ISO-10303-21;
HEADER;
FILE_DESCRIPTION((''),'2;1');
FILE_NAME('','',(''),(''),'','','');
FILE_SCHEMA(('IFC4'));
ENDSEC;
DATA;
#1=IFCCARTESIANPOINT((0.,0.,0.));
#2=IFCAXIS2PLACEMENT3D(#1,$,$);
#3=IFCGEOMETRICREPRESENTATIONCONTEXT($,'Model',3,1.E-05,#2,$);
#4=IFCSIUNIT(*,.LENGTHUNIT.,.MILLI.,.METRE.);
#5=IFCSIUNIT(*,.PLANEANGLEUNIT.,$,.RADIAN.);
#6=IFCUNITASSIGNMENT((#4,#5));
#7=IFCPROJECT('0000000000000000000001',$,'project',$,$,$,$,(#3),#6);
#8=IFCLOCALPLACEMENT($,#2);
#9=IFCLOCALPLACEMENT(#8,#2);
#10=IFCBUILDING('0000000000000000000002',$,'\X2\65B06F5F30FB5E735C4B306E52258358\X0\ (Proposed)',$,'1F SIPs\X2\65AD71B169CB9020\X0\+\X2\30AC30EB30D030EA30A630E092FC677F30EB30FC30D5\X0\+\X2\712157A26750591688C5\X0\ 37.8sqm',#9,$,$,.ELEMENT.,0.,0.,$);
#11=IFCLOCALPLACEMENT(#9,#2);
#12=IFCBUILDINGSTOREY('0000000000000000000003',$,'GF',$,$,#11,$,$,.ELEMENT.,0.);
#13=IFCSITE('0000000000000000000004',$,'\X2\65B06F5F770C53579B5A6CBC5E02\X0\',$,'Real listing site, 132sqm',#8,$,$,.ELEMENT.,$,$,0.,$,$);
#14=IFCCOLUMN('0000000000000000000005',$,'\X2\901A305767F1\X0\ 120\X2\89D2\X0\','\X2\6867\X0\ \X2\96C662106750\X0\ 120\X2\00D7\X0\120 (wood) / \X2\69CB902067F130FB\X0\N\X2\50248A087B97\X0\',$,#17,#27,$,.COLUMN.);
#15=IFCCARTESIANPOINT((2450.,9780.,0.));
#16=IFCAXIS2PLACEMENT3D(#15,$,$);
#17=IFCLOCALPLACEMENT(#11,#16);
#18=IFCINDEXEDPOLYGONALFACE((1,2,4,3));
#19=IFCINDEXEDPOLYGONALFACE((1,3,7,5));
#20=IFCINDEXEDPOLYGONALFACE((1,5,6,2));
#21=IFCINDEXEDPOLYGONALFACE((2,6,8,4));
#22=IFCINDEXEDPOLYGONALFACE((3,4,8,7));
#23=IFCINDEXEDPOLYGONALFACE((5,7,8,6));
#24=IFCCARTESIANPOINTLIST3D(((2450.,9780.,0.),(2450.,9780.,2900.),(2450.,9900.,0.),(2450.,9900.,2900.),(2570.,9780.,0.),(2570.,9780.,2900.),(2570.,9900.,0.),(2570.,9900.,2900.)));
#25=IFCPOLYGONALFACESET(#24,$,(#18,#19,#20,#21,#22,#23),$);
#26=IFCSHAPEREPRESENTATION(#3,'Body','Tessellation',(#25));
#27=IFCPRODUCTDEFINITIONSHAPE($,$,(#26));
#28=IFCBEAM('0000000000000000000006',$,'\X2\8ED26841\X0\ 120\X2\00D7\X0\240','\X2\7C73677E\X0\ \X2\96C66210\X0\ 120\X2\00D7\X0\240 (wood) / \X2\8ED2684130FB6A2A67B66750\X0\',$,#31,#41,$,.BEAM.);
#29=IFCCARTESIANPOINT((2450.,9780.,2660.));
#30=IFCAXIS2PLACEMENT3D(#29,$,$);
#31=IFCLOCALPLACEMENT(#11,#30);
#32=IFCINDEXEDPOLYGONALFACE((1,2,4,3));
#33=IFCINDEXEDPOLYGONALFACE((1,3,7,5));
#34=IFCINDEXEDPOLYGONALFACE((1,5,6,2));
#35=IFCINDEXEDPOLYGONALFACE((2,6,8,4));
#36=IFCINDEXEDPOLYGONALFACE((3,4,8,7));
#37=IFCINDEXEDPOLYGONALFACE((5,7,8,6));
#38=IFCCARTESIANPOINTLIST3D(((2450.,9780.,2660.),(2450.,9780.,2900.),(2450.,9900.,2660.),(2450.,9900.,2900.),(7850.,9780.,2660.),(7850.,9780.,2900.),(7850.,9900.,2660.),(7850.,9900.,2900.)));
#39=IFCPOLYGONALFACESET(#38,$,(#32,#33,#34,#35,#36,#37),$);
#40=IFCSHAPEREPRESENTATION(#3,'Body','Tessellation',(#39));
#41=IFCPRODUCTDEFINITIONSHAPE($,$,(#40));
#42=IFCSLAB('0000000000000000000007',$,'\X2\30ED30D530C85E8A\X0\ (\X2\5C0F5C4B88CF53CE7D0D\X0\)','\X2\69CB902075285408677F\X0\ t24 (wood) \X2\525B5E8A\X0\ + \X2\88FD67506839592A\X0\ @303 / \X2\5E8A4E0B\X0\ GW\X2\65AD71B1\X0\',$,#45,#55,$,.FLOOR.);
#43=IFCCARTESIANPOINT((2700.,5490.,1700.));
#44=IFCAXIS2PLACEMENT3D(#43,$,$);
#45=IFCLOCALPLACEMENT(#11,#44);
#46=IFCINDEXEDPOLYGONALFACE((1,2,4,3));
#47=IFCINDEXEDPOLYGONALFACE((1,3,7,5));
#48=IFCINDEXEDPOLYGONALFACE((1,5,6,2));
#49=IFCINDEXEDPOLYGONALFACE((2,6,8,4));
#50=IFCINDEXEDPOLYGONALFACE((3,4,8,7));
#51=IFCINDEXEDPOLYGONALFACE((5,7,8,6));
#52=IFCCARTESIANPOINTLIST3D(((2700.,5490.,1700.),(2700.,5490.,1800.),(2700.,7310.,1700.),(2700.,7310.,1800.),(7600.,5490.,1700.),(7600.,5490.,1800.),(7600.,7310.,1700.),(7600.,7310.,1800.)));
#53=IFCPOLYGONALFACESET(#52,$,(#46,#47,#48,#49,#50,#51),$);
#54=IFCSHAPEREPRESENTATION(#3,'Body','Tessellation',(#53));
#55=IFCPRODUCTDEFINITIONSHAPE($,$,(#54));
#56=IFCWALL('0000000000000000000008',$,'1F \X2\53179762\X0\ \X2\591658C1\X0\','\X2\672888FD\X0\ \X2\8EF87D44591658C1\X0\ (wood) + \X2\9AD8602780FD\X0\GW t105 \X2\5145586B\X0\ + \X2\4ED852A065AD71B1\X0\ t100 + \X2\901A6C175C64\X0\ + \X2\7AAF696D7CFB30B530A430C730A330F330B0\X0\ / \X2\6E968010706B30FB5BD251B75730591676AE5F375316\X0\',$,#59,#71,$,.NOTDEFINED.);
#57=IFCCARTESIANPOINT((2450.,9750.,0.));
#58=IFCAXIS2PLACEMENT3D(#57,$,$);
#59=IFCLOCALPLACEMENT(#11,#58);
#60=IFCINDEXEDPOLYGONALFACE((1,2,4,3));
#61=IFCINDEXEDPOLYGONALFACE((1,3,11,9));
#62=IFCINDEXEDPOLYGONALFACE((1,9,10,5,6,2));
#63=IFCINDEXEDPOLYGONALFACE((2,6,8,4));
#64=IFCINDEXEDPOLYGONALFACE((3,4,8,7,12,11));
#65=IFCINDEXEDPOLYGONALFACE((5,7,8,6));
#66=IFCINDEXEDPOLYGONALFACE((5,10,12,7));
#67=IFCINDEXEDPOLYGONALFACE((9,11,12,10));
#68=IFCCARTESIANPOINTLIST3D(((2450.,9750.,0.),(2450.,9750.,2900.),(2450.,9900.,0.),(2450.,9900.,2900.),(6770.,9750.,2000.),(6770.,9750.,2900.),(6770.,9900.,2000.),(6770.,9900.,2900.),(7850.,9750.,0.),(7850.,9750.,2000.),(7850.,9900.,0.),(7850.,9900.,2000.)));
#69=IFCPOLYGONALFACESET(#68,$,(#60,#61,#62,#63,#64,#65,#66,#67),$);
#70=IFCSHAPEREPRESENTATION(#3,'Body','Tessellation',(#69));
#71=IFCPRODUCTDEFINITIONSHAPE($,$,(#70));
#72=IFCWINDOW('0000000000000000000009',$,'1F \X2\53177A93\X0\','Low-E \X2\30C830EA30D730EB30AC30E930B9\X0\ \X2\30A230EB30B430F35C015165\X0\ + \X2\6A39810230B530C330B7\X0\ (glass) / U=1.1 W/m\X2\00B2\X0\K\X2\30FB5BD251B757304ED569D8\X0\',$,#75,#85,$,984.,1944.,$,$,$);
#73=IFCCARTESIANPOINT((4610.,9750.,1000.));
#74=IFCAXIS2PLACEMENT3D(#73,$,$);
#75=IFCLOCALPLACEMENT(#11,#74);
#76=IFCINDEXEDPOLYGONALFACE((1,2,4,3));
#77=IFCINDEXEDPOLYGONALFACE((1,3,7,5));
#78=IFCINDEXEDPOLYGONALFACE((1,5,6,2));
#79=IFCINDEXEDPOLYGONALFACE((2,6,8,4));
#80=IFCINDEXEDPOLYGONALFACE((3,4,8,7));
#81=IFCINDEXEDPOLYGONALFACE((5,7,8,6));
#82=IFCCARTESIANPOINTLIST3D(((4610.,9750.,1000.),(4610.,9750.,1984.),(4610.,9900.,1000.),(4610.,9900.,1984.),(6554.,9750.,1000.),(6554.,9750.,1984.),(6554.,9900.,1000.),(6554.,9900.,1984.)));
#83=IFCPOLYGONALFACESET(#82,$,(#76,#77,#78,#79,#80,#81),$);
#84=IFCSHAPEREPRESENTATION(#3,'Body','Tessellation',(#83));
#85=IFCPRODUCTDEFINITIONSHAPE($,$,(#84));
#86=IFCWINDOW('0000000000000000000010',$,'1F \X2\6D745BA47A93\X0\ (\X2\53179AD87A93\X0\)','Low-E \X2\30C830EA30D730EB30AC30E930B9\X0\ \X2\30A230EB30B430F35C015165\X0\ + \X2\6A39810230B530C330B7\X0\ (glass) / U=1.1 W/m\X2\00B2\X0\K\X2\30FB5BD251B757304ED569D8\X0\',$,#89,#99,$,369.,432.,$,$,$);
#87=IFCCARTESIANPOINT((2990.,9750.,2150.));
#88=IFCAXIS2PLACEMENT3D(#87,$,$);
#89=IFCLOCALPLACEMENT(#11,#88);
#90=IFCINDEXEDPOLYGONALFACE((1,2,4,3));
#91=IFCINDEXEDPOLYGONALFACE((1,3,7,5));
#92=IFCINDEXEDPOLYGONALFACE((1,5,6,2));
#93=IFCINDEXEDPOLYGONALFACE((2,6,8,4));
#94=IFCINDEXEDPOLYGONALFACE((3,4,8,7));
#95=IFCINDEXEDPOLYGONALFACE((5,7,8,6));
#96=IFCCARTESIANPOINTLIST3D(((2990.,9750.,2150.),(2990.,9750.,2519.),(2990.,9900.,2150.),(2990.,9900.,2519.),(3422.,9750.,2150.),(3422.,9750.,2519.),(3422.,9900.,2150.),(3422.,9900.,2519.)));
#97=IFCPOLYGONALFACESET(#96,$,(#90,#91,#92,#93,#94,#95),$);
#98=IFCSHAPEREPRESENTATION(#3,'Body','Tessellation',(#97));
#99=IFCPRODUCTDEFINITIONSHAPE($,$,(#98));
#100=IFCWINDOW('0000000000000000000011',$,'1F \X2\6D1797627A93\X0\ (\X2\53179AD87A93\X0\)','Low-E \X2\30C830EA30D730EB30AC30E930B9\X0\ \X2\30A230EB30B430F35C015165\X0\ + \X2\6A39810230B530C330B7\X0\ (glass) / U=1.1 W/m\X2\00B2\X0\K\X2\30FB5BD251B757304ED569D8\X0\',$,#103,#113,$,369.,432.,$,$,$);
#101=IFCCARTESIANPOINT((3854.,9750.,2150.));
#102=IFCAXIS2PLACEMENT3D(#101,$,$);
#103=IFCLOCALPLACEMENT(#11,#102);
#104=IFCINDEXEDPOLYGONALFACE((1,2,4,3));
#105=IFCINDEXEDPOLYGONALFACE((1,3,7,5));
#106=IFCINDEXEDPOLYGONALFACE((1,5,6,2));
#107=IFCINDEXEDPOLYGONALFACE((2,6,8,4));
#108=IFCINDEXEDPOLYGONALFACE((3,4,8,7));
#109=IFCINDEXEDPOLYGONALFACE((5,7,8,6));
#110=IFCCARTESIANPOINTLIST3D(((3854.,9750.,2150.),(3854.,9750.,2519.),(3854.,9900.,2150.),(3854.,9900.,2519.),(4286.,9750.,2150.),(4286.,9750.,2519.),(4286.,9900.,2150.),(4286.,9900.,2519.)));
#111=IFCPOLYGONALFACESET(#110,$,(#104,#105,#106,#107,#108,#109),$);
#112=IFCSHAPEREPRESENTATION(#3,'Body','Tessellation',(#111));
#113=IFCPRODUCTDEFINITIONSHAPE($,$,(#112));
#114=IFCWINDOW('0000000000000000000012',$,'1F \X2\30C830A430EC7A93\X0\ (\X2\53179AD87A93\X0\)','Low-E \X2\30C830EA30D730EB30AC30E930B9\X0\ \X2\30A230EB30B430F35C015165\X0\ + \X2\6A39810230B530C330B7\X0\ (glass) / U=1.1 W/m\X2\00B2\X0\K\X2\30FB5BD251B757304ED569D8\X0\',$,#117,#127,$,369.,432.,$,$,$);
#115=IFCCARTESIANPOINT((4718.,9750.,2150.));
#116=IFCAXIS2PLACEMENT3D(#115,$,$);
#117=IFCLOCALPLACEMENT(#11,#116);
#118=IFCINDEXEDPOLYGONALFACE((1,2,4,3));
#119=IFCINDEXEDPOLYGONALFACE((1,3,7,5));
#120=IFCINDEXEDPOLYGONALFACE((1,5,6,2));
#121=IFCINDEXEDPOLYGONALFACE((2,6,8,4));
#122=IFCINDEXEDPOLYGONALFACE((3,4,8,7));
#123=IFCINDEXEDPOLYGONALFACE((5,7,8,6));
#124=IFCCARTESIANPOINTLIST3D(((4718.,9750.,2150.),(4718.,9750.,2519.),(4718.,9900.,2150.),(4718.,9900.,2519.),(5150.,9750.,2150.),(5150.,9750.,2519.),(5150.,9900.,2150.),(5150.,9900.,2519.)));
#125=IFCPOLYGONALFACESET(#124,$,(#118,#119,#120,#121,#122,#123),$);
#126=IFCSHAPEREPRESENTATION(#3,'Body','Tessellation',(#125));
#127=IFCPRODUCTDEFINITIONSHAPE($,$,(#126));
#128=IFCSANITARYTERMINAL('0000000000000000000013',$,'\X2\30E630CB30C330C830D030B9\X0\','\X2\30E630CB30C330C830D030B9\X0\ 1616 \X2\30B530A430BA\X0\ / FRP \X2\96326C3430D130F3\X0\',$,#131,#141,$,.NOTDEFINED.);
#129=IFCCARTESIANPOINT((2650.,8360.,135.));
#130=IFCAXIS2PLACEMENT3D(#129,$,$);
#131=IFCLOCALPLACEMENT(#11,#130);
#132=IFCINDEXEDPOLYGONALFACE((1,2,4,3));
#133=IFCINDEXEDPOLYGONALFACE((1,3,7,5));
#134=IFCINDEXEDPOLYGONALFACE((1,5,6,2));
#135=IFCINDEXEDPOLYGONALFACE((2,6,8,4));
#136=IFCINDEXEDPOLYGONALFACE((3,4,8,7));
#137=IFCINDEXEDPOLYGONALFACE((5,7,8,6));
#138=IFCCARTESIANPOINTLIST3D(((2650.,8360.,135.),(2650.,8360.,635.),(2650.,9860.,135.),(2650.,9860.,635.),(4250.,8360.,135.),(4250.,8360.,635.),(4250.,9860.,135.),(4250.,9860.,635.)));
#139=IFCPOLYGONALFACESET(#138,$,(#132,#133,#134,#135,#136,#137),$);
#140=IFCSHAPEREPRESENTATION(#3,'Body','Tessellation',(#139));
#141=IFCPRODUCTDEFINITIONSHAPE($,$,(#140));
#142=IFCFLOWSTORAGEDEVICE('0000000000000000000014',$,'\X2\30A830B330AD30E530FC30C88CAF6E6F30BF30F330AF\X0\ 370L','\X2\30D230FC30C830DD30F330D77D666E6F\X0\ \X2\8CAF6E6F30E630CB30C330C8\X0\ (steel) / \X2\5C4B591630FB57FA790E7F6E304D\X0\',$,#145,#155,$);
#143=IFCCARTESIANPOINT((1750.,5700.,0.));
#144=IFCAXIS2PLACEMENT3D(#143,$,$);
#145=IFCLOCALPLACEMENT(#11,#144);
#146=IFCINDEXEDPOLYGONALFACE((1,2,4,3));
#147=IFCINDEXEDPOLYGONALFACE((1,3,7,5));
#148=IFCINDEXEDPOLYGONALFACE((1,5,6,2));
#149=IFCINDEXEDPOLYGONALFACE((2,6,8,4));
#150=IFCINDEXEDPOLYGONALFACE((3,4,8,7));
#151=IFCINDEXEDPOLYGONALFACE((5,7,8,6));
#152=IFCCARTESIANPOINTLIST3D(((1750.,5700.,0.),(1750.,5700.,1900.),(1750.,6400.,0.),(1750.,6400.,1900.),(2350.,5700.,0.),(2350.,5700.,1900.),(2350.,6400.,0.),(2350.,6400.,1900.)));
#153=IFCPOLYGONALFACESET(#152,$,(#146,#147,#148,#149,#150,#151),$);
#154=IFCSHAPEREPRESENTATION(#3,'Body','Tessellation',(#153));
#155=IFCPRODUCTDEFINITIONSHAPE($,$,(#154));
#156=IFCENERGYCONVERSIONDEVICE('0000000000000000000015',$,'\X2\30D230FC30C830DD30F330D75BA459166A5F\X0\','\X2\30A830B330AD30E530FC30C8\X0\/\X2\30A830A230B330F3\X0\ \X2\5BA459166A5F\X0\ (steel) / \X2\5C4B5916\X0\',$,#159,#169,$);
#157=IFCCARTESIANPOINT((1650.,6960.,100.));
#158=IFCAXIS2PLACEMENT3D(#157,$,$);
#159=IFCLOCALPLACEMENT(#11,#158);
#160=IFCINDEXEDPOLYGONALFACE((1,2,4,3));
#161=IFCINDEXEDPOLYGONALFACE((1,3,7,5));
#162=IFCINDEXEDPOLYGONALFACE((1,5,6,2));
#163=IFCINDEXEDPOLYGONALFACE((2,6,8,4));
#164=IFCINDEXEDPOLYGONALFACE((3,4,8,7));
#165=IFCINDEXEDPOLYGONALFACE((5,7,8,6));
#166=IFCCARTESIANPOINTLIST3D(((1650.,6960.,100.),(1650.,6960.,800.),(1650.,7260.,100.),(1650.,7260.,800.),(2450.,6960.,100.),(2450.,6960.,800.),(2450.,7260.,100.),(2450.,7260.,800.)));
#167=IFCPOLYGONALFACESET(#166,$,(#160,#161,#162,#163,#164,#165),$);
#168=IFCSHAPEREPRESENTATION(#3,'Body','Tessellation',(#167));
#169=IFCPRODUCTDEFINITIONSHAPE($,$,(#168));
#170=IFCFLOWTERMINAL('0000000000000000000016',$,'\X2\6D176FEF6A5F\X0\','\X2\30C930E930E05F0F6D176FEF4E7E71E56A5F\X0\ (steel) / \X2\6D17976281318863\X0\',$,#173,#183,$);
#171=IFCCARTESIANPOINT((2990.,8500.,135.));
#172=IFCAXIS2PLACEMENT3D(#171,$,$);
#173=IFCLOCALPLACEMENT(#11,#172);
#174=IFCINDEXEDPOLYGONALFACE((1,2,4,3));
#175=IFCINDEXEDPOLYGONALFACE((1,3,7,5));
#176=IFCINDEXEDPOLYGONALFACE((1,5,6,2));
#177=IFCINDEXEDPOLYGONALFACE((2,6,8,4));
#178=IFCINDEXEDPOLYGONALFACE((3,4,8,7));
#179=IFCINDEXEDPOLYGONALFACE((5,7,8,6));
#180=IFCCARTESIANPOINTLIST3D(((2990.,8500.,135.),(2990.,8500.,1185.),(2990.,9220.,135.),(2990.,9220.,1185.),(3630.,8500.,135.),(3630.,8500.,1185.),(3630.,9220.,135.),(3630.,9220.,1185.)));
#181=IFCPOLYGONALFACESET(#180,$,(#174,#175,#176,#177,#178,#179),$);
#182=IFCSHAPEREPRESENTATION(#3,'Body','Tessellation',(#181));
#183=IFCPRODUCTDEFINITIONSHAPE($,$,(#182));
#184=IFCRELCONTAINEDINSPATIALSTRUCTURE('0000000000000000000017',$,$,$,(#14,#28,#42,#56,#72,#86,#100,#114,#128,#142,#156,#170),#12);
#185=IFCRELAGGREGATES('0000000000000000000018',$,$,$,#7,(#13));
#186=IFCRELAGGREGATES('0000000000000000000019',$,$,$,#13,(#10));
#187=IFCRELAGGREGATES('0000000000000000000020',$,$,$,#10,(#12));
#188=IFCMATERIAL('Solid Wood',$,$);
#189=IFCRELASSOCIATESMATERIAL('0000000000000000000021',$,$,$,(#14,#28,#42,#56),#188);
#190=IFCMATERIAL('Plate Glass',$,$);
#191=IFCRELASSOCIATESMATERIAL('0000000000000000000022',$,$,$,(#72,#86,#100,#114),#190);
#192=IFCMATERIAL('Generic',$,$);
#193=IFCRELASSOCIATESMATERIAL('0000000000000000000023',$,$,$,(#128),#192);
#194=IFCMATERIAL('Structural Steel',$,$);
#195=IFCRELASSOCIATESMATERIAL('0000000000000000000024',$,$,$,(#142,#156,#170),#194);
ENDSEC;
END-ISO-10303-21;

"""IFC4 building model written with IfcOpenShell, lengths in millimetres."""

from ifc_helpers import new_model, si_unit, frame, frame_2d, origin, place, context, project, spatial, rectangle, extrude, material, element, fill, save


model = new_model("IFC4")

# Units and contexts
model_context = context("Model", 3, precision=1e-05, world=origin())
ifc_project = project(units=[si_unit("LENGTHUNIT", "METRE", prefix="MILLI"), si_unit("PLANEANGLEUNIT", "RADIAN")], contexts=[model_context])

# Site, building, storey
site_placement = place(None, origin())
site = spatial("IfcSite", under=ifc_project, at=site_placement, Name="新潟県南魚沼市", ObjectType="Real listing site, 132sqm", CompositionType="ELEMENT", RefElevation=0.0)
building_placement = place(site_placement, origin())
building = spatial("IfcBuilding", under=site, at=building_placement, Name="新潟・平屋の別荘 (Proposed)", ObjectType="1F SIPs断熱構造+ガルバリウム鋼板ルーフ+無垢材外装 37.8sqm", CompositionType="ELEMENT", ElevationOfRefHeight=0.0, ElevationOfTerrain=0.0)
storey_placement = place(building_placement, origin())
storey = spatial("IfcBuildingStorey", under=building, at=storey_placement, Name="GF", CompositionType="ELEMENT", Elevation=0.0)

# Column
ifc_material_1 = material(Name="Solid Wood")
column_1_placement = place(storey_placement, frame((2450.0, 9780.0, 0.0)))
element("IfcColumn", 1, at=column_1_placement, inside=storey, material=ifc_material_1, Name="通し柱 120角", Description="桧 集成材 120×120 (wood) / 構造柱・N値計算", PredefinedType="COLUMN", context=model_context, shape_type="SweptSolid", body=[
    extrude(rectangle(XDim=120.0, YDim=120.0, at=frame_2d((60.0, 60.0))), frame((2450.0, 9780.0, 0.0)), (0.0, 0.0, 1.0), 2900.0),
])

# Beam
beam_1_placement = place(storey_placement, frame((2450.0, 9780.0, 2660.0)))
element("IfcBeam", 2, at=beam_1_placement, inside=storey, material=ifc_material_1, Name="軒桁 120×240", Description="米松 集成 120×240 (wood) / 軒桁・横架材", PredefinedType="BEAM", context=model_context, shape_type="SweptSolid", body=[
    extrude(rectangle(XDim=5400.0, YDim=120.0, at=frame_2d((2700.0, 60.0))), frame((2450.0, 9780.0, 2660.0)), (0.0, 0.0, 1.0), 240.0),
])

# Slab
slab_placement = place(storey_placement, frame((2700.0, 5490.0, 1700.0)))
element("IfcSlab", 3, at=slab_placement, inside=storey, material=ifc_material_1, Name="ロフト床 (小屋裏収納)", Description="構造用合板 t24 (wood) 剛床 + 製材根太 @303 / 床下 GW断熱", PredefinedType="FLOOR", context=model_context, shape_type="SweptSolid", body=[
    extrude(rectangle(XDim=4900.0, YDim=1820.0, at=frame_2d((2450.0, 910.0))), frame((2700.0, 5490.0, 1700.0)), (0.0, 0.0, 1.0), 100.0),
])

# Wall, openings, windows
wall_1_placement = place(storey_placement, frame((2450.0, 9750.0, 0.0)))
wall_1 = element("IfcWall", 4, at=wall_1_placement, inside=storey, material=ifc_material_1, Name="1F 北面 外壁", Description="木製 軸組外壁 (wood) + 高性能GW t105 充填 + 付加断熱 t100 + 通気層 + 窯業系サイディング / 準耐火・寒冷地外皮強化", PredefinedType="NOTDEFINED", context=model_context, shape_type="SweptSolid", body=[
    extrude(rectangle(XDim=5400.0, YDim=150.0, at=frame_2d((2700.0, 75.0))), frame((2450.0, 9750.0, 0.0)), (0.0, 0.0, 1.0), 2900.0),
])
opening_1_placement = place(storey_placement, frame((4610.0, 9750.0, 1000.0)))
opening_1 = element("IfcOpeningElement", 5, at=opening_1_placement, cuts=wall_1, PredefinedType="NOTDEFINED", context=model_context, shape_type="SweptSolid", body=[
    extrude(rectangle(XDim=1944.0, YDim=150.0, at=frame_2d((972.0, 75.0))), frame((4610.0, 9750.0, 1000.0)), (0.0, 0.0, 1.0), 984.0),
])
opening_2_placement = place(storey_placement, frame((2990.0, 9750.0, 2150.0)))
opening_2 = element("IfcOpeningElement", 6, at=opening_2_placement, cuts=wall_1, PredefinedType="NOTDEFINED", context=model_context, shape_type="SweptSolid", body=[
    extrude(rectangle(XDim=432.0, YDim=150.0, at=frame_2d((216.0, 75.0))), frame((2990.0, 9750.0, 2150.0)), (0.0, 0.0, 1.0), 369.0),
])
opening_3_placement = place(storey_placement, frame((3854.0, 9750.0, 2150.0)))
opening_3 = element("IfcOpeningElement", 7, at=opening_3_placement, cuts=wall_1, PredefinedType="NOTDEFINED", context=model_context, shape_type="SweptSolid", body=[
    extrude(rectangle(XDim=432.0, YDim=150.0, at=frame_2d((216.0, 75.0))), frame((3854.0, 9750.0, 2150.0)), (0.0, 0.0, 1.0), 369.0),
])
opening_4_placement = place(storey_placement, frame((4718.0, 9750.0, 2150.0)))
opening_4 = element("IfcOpeningElement", 8, at=opening_4_placement, cuts=wall_1, PredefinedType="NOTDEFINED", context=model_context, shape_type="SweptSolid", body=[
    extrude(rectangle(XDim=432.0, YDim=150.0, at=frame_2d((216.0, 75.0))), frame((4718.0, 9750.0, 2150.0)), (0.0, 0.0, 1.0), 369.0),
])
ifc_material_2 = material(Name="Plate Glass")
window_1_placement = place(storey_placement, frame((4610.0, 9750.0, 1000.0)))
window_1 = element("IfcWindow", 9, at=window_1_placement, inside=storey, material=ifc_material_2, Name="1F 北窓", Description="Low-E トリプルガラス アルゴン封入 + 樹脂サッシ (glass) / U=1.1 W/m²K・寒冷地仕様", OverallHeight=984.0, OverallWidth=1944.0, context=model_context, shape_type="SweptSolid", body=[
    extrude(rectangle(XDim=1944.0, YDim=150.0, at=frame_2d((972.0, 75.0))), frame((4610.0, 9750.0, 1000.0)), (0.0, 0.0, 1.0), 984.0),
])
fill(opening_1, window_1)
window_2_placement = place(storey_placement, frame((2990.0, 9750.0, 2150.0)))
window_2 = element("IfcWindow", 10, at=window_2_placement, inside=storey, material=ifc_material_2, Name="1F 浴室窓 (北高窓)", Description="Low-E トリプルガラス アルゴン封入 + 樹脂サッシ (glass) / U=1.1 W/m²K・寒冷地仕様", OverallHeight=369.0, OverallWidth=432.0, context=model_context, shape_type="SweptSolid", body=[
    extrude(rectangle(XDim=432.0, YDim=150.0, at=frame_2d((216.0, 75.0))), frame((2990.0, 9750.0, 2150.0)), (0.0, 0.0, 1.0), 369.0),
])
fill(opening_2, window_2)
window_3_placement = place(storey_placement, frame((3854.0, 9750.0, 2150.0)))
window_3 = element("IfcWindow", 11, at=window_3_placement, inside=storey, material=ifc_material_2, Name="1F 洗面窓 (北高窓)", Description="Low-E トリプルガラス アルゴン封入 + 樹脂サッシ (glass) / U=1.1 W/m²K・寒冷地仕様", OverallHeight=369.0, OverallWidth=432.0, context=model_context, shape_type="SweptSolid", body=[
    extrude(rectangle(XDim=432.0, YDim=150.0, at=frame_2d((216.0, 75.0))), frame((3854.0, 9750.0, 2150.0)), (0.0, 0.0, 1.0), 369.0),
])
fill(opening_3, window_3)
window_4_placement = place(storey_placement, frame((4718.0, 9750.0, 2150.0)))
window_4 = element("IfcWindow", 12, at=window_4_placement, inside=storey, material=ifc_material_2, Name="1F トイレ窓 (北高窓)", Description="Low-E トリプルガラス アルゴン封入 + 樹脂サッシ (glass) / U=1.1 W/m²K・寒冷地仕様", OverallHeight=369.0, OverallWidth=432.0, context=model_context, shape_type="SweptSolid", body=[
    extrude(rectangle(XDim=432.0, YDim=150.0, at=frame_2d((216.0, 75.0))), frame((4718.0, 9750.0, 2150.0)), (0.0, 0.0, 1.0), 369.0),
])
fill(opening_4, window_4)

# Sanitary terminal
ifc_material_3 = material(Name="Generic")
sanitary_terminal_placement = place(storey_placement, frame((2650.0, 8360.0, 135.0)))
element("IfcSanitaryTerminal", 13, at=sanitary_terminal_placement, inside=storey, material=ifc_material_3, Name="ユニットバス", Description="ユニットバス 1616 サイズ / FRP 防水パン", PredefinedType="NOTDEFINED", context=model_context, shape_type="SweptSolid", body=[
    extrude(rectangle(XDim=1600.0, YDim=1500.0, at=frame_2d((800.0, 750.0))), frame((2650.0, 8360.0, 135.0)), (0.0, 0.0, 1.0), 500.0),
])

# Flow storage device
ifc_material_4 = material(Name="Structural Steel")
flow_storage_device_placement = place(storey_placement, frame((1750.0, 5700.0, 0.0)))
element("IfcFlowStorageDevice", 14, at=flow_storage_device_placement, inside=storey, material=ifc_material_4, Name="エコキュート貯湯タンク 370L", Description="ヒートポンプ給湯 貯湯ユニット (steel) / 屋外・基礎置き", context=model_context, shape_type="SweptSolid", body=[
    extrude(rectangle(XDim=600.0, YDim=700.0, at=frame_2d((300.0, 350.0))), frame((1750.0, 5700.0, 0.0)), (0.0, 0.0, 1.0), 1900.0),
])

# Energy conversion device
energy_conversion_device_placement = place(storey_placement, frame((1650.0, 6960.0, 100.0)))
element("IfcEnergyConversionDevice", 15, at=energy_conversion_device_placement, inside=storey, material=ifc_material_4, Name="ヒートポンプ室外機", Description="エコキュート/エアコン 室外機 (steel) / 屋外", context=model_context, shape_type="SweptSolid", body=[
    extrude(rectangle(XDim=800.0, YDim=300.0, at=frame_2d((400.0, 150.0))), frame((1650.0, 6960.0, 100.0)), (0.0, 0.0, 1.0), 700.0),
])

# Flow terminal
flow_terminal_placement = place(storey_placement, frame((2990.0, 8500.0, 135.0)))
element("IfcFlowTerminal", 16, at=flow_terminal_placement, inside=storey, material=ifc_material_4, Name="洗濯機", Description="ドラム式洗濯乾燥機 (steel) / 洗面脱衣", context=model_context, shape_type="SweptSolid", body=[
    extrude(rectangle(XDim=640.0, YDim=720.0, at=frame_2d((320.0, 360.0))), frame((2990.0, 8500.0, 135.0)), (0.0, 0.0, 1.0), 1050.0),
])

save(model, "model.ifc")
